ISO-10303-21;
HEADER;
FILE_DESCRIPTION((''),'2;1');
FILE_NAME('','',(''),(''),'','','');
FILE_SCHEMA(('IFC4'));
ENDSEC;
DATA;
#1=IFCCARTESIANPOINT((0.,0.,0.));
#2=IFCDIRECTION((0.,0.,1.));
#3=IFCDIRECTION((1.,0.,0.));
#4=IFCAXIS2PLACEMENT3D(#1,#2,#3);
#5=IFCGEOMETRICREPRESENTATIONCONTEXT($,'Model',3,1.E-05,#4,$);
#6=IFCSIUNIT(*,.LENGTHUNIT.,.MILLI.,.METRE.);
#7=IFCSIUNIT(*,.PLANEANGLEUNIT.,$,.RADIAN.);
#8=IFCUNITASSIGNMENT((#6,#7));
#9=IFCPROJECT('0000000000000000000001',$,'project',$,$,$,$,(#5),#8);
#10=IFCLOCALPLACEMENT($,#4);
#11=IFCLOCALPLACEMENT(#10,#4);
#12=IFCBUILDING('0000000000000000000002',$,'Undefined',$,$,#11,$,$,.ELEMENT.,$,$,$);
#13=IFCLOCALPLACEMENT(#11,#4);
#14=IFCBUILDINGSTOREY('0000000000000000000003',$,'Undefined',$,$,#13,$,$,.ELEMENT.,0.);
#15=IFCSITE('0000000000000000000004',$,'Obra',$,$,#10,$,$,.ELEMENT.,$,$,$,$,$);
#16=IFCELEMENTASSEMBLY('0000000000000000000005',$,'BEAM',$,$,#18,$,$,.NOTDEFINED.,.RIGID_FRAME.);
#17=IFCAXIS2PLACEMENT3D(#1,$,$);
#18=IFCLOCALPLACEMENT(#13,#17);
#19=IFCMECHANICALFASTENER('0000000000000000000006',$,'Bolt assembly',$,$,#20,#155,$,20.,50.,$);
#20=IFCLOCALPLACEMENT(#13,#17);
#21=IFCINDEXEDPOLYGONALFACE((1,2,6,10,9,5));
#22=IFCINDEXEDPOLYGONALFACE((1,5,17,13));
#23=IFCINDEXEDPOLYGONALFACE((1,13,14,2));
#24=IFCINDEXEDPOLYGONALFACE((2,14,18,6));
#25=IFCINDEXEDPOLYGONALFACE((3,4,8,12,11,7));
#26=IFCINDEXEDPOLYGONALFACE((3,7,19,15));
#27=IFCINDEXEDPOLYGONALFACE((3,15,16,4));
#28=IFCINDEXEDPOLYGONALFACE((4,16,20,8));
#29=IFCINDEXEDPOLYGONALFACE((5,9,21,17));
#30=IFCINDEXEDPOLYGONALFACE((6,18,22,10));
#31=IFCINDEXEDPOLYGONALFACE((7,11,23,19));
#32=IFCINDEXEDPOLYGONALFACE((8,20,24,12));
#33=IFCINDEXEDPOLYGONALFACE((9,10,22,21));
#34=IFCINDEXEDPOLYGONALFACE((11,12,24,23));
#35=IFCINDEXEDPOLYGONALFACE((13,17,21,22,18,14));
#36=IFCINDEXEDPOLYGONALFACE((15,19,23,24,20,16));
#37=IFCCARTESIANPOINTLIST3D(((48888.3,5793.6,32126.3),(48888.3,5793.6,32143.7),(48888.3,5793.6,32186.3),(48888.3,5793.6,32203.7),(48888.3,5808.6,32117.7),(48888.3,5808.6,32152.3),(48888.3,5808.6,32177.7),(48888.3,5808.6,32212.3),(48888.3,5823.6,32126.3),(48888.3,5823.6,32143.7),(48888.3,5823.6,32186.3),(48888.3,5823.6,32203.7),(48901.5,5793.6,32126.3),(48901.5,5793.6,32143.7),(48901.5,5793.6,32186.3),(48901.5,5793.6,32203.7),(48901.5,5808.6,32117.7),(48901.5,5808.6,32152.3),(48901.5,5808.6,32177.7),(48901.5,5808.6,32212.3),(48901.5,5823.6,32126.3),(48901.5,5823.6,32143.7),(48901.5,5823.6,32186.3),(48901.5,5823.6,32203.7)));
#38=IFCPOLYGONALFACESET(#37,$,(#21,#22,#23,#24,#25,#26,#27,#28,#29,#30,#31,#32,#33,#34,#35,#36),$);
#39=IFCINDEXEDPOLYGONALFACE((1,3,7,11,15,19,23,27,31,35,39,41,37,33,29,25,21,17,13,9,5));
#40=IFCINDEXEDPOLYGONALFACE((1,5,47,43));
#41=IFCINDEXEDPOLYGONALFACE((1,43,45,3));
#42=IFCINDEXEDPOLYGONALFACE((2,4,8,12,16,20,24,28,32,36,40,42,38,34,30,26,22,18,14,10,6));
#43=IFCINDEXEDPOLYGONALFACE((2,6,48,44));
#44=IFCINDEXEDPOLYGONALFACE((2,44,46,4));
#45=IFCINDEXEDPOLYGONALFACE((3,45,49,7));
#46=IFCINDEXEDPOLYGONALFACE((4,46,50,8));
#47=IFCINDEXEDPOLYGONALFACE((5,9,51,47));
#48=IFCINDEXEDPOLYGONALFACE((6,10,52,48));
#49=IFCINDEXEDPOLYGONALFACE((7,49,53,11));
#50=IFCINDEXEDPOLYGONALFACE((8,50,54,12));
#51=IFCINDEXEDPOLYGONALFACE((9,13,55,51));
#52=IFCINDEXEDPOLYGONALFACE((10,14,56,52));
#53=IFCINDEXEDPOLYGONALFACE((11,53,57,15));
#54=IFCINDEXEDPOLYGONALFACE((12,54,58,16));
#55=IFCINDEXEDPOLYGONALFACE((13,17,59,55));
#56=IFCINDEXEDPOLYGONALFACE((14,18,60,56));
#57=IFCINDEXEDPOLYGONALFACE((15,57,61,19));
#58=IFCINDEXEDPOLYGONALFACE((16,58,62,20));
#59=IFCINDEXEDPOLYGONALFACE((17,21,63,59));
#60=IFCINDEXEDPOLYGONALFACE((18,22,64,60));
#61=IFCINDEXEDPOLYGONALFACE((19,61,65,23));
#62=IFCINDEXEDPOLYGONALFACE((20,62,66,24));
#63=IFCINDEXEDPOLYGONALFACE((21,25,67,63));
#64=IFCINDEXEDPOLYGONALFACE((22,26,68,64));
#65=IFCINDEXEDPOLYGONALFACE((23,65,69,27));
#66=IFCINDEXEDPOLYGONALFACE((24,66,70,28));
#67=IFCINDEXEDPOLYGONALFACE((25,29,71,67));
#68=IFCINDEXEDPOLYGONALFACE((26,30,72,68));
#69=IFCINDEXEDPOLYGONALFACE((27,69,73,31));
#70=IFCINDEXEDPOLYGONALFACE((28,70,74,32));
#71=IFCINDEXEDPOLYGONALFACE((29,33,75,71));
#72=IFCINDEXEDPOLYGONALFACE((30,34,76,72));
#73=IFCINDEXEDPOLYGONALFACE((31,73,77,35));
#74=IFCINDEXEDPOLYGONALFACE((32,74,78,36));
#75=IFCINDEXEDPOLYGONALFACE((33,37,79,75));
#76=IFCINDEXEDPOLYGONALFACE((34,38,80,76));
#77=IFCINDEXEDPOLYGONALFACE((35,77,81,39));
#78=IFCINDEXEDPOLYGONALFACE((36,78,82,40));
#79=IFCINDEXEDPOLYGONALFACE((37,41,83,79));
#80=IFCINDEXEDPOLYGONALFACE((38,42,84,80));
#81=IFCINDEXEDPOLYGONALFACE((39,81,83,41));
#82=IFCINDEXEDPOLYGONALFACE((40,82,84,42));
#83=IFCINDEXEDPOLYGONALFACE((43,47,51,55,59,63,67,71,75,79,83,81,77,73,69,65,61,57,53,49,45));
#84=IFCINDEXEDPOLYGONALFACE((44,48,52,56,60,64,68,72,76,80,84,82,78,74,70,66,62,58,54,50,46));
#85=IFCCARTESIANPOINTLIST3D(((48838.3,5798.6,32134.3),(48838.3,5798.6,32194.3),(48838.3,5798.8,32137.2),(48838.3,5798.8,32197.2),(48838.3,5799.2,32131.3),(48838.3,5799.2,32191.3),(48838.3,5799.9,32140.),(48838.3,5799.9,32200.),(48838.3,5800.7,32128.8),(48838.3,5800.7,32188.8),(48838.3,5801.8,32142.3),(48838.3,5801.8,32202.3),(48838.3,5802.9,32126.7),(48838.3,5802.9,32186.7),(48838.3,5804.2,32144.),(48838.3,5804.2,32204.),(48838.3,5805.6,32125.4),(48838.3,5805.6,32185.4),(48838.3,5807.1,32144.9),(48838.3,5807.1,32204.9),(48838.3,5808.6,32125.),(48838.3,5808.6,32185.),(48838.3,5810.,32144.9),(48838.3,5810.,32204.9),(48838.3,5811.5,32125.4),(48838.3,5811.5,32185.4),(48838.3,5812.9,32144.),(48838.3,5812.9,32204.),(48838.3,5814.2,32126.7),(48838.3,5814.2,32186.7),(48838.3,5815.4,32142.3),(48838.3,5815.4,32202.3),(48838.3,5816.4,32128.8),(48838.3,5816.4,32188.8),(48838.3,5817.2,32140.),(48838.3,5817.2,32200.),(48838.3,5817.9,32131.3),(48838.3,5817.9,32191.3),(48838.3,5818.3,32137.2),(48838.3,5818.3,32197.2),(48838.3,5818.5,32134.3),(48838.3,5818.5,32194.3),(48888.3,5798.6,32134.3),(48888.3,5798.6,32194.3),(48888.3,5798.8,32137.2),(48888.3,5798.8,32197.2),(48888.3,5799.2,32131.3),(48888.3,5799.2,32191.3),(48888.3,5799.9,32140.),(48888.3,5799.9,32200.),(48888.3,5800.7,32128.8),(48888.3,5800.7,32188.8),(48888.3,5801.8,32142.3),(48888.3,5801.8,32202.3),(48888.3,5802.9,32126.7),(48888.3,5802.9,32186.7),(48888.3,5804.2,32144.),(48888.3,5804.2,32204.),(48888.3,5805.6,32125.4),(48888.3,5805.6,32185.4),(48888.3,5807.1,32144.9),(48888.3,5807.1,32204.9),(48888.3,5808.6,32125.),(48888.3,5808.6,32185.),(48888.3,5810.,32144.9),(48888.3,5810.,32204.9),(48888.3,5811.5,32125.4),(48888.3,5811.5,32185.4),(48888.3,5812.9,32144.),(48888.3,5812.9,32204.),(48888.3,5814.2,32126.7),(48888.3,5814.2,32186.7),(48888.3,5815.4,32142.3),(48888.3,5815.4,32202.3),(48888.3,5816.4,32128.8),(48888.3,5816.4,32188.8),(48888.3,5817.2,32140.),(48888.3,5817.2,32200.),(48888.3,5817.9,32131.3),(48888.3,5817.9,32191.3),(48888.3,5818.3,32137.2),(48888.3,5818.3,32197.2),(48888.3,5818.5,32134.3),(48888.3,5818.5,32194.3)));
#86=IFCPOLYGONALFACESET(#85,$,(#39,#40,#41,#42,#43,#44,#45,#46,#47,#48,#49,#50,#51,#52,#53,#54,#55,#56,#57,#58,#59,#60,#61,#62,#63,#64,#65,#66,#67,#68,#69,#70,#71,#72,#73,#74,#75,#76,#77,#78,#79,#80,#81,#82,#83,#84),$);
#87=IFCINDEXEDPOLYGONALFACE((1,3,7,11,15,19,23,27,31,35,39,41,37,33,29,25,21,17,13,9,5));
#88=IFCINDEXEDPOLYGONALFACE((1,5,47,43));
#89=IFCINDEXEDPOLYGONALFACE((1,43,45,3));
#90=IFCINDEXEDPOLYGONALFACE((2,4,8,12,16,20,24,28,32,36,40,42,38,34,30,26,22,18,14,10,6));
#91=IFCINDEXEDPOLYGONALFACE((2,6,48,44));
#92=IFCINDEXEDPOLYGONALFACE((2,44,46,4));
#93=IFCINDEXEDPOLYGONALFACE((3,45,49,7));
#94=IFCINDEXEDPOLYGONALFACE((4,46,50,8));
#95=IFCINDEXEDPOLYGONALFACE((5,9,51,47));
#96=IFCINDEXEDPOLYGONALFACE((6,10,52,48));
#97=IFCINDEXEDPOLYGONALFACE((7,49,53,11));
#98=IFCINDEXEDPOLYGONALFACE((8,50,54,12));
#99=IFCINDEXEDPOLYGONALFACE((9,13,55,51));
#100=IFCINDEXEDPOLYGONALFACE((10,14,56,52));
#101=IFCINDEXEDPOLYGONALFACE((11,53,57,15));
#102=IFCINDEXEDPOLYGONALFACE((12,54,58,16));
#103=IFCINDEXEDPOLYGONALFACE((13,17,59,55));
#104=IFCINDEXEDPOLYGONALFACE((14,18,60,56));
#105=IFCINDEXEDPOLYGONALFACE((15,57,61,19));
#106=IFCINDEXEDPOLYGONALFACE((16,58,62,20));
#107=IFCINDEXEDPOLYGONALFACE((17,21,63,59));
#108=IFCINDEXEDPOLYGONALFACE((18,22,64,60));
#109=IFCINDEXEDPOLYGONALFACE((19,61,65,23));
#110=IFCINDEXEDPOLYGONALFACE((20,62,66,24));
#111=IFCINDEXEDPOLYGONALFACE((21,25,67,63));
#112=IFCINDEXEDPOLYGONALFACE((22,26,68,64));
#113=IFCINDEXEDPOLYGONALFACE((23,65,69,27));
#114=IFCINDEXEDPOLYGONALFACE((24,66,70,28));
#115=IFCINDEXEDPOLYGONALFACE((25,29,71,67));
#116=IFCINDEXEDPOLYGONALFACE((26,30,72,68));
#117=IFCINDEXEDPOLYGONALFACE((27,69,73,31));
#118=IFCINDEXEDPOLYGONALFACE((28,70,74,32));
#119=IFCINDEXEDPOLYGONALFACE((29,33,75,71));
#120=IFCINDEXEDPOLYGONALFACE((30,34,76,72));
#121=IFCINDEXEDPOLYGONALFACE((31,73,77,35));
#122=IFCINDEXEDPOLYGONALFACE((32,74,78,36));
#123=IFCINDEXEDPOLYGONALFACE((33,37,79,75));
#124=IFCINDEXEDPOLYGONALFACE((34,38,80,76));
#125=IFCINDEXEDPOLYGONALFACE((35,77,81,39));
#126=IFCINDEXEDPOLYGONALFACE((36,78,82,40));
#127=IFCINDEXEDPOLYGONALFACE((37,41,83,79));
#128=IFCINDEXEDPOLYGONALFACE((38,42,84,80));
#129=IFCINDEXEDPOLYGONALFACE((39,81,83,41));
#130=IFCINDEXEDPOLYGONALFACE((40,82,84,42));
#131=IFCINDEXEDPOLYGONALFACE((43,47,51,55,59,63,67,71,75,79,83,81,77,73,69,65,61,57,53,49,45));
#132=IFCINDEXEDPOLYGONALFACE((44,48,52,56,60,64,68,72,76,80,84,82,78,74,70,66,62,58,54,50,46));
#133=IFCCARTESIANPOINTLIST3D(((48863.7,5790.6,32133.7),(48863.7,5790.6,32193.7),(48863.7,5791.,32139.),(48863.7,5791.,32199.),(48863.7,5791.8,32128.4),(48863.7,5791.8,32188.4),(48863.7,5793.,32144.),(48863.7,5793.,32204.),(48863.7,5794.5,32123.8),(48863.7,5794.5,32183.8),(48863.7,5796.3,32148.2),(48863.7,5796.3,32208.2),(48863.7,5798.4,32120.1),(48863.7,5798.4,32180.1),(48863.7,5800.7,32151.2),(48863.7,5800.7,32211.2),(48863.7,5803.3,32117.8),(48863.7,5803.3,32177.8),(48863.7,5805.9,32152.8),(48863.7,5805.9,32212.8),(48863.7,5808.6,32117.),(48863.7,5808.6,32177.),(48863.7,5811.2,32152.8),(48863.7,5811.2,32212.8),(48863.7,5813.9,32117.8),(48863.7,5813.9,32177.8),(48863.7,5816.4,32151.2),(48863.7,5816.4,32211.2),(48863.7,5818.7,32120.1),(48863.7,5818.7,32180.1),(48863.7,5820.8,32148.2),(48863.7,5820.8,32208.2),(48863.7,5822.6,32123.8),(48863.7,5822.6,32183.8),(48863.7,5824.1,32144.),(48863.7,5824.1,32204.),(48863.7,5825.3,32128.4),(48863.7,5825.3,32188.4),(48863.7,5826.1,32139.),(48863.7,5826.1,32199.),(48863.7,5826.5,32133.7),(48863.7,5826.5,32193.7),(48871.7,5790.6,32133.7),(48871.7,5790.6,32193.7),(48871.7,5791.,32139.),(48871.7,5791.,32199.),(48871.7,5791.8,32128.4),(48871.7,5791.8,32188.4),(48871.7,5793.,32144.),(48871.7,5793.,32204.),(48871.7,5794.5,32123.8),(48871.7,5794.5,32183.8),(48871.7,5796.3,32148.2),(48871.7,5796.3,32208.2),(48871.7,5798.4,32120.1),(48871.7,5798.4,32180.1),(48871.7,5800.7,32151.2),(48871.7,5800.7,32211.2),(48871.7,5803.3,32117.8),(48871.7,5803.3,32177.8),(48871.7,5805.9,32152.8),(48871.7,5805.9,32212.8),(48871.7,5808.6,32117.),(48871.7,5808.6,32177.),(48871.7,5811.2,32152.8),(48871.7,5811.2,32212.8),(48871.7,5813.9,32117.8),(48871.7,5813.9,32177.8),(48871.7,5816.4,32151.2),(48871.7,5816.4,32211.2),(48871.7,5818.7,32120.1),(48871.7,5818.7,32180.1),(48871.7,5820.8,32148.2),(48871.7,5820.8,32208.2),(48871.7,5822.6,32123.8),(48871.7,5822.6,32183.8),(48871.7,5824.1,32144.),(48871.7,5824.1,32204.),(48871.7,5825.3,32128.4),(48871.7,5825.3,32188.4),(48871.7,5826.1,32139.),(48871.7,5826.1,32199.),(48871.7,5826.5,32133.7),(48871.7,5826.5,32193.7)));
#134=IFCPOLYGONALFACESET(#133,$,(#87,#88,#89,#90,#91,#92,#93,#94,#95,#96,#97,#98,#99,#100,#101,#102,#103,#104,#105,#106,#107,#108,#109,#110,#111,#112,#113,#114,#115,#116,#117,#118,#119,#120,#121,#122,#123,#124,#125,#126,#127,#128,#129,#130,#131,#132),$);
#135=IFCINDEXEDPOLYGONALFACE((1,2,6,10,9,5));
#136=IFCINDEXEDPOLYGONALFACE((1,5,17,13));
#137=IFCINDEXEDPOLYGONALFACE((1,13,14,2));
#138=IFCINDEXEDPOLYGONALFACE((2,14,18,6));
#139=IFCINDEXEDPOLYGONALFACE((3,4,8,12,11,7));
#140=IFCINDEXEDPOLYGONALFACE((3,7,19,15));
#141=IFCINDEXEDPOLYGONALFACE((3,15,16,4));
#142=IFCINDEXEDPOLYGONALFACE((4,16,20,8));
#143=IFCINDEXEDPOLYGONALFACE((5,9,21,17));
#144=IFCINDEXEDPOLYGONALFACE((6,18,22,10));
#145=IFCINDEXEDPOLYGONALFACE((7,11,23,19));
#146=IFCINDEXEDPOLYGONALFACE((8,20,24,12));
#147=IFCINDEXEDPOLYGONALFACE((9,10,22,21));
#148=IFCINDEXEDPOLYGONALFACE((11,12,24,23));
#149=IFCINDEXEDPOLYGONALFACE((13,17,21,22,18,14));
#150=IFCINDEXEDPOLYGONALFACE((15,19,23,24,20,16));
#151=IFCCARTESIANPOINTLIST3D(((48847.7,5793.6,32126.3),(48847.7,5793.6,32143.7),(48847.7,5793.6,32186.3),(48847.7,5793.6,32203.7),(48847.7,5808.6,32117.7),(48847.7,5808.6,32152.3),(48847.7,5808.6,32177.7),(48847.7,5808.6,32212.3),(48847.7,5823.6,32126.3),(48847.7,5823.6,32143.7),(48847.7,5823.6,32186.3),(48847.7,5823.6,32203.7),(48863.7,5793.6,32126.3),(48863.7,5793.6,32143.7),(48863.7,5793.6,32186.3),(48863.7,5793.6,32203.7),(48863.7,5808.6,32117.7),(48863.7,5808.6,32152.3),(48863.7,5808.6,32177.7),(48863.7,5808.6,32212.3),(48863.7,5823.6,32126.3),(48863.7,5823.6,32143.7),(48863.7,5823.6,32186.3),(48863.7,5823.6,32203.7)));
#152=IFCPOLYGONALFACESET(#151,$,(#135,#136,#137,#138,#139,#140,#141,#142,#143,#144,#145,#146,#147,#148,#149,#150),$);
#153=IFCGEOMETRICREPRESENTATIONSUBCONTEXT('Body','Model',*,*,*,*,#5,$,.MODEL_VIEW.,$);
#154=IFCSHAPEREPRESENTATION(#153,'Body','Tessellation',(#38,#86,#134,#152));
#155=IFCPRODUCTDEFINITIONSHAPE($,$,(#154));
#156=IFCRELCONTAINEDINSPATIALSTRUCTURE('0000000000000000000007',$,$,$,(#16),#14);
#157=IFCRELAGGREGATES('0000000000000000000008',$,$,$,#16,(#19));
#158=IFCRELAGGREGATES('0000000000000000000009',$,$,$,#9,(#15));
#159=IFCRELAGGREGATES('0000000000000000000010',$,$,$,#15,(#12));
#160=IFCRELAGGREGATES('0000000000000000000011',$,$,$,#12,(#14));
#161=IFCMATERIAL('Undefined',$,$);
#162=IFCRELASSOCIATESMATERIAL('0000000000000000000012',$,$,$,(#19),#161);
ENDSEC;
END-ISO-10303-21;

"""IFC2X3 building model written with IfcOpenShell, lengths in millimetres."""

from ifc_helpers import new_model, si_unit, frame, origin_with_axes, origin_2d_with_axis, place, context, subcontext, project, spatial, polyline, circle, outline, extrude, source, transform, mapped, material, element, aggregate, save


model = new_model("IFC2X3")

# Units and contexts
model_context = context("Model", 3, precision=1e-05, world=origin_with_axes())
body_context = subcontext(model_context, "Body", "Model", "MODEL_VIEW")
ifc_project = project(units=[si_unit("LENGTHUNIT", "METRE", prefix="MILLI"), si_unit("PLANEANGLEUNIT", "RADIAN")], contexts=[model_context])

# Site, building, storey
site_placement = place(None, origin_with_axes())
site = spatial("IfcSite", under=ifc_project, at=site_placement, Name="Obra", CompositionType="ELEMENT")
building_placement = place(site_placement, origin_with_axes())
building = spatial("IfcBuilding", under=site, at=building_placement, Name="Undefined", CompositionType="ELEMENT")
storey_placement = place(building_placement, origin_with_axes())
storey = spatial("IfcBuildingStorey", under=building, at=storey_placement, Name="Undefined", CompositionType="ELEMENT", Elevation=0.0)

# Shared definitions
ifc_material_1 = material(Name="Undefined")

# Element assembly, mechanical fastener
assembly_1_placement = place(storey_placement, origin_with_axes())
assembly_1 = element("IfcElementAssembly", 1, at=assembly_1_placement, inside=storey, Name="BEAM", AssemblyPlace="NOTDEFINED", PredefinedType="RIGID_FRAME")
shared_shape_1 = source(origin_with_axes(), body_context, "Body", "SweptSolid", [
    extrude(outline(polyline([(17.3, 0.0), (8.7, 15.0), (-8.7, 15.0), (-17.3, 0.0), (-8.7, -15.0), (8.7, -15.0), (17.3, 0.0)])), frame((0.0, -26.5, 0.0), z_axis=(0.0, 1.0, 0.0), x_axis=(1.0, 0.0, 0.0)), (0.0, 0.0, 1.0), 13.2),
    extrude(circle(Radius=10.0, at=origin_2d_with_axis()), frame((0.0, -13.3, 0.0), z_axis=(0.0, 1.0, 0.0), x_axis=(1.0, 0.0, 0.0)), (0.0, 0.0, 1.0), 50.0),
    extrude(circle(Radius=18.0, at=origin_2d_with_axis()), frame((0.0, 3.3, 0.0), z_axis=(0.0, 1.0, 0.0), x_axis=(1.0, 0.0, 0.0)), (0.0, 0.0, 1.0), 8.0),
    extrude(outline(polyline([(17.3, 0.0), (8.7, 15.0), (-8.7, 15.0), (-17.3, 0.0), (-8.7, -15.0), (8.7, -15.0), (17.3, 0.0)])), frame((0.0, 11.3, 0.0), z_axis=(0.0, 1.0, 0.0), x_axis=(1.0, 0.0, 0.0)), (0.0, 0.0, 1.0), 16.0),
])
mechanical_fastener_1_placement = place(assembly_1_placement, frame((48875.0, 5768.6, 32235.0), z_axis=(0.0, 1.0, 0.0), x_axis=(0.0, 0.0, -1.0)))
mechanical_fastener_1 = element("IfcMechanicalFastener", 2, at=mechanical_fastener_1_placement, material=ifc_material_1, Name="Bolt assembly", NominalDiameter=20.0, NominalLength=50.0, context=body_context, shape_type="MappedRepresentation", body=[
    mapped(shared_shape_1, transform((40.0, 0.0, 40.0))),
    mapped(shared_shape_1, transform((100.0, 0.0, 40.0))),
])
aggregate(assembly_1, [mechanical_fastener_1])

save(model, "model.ifc")
